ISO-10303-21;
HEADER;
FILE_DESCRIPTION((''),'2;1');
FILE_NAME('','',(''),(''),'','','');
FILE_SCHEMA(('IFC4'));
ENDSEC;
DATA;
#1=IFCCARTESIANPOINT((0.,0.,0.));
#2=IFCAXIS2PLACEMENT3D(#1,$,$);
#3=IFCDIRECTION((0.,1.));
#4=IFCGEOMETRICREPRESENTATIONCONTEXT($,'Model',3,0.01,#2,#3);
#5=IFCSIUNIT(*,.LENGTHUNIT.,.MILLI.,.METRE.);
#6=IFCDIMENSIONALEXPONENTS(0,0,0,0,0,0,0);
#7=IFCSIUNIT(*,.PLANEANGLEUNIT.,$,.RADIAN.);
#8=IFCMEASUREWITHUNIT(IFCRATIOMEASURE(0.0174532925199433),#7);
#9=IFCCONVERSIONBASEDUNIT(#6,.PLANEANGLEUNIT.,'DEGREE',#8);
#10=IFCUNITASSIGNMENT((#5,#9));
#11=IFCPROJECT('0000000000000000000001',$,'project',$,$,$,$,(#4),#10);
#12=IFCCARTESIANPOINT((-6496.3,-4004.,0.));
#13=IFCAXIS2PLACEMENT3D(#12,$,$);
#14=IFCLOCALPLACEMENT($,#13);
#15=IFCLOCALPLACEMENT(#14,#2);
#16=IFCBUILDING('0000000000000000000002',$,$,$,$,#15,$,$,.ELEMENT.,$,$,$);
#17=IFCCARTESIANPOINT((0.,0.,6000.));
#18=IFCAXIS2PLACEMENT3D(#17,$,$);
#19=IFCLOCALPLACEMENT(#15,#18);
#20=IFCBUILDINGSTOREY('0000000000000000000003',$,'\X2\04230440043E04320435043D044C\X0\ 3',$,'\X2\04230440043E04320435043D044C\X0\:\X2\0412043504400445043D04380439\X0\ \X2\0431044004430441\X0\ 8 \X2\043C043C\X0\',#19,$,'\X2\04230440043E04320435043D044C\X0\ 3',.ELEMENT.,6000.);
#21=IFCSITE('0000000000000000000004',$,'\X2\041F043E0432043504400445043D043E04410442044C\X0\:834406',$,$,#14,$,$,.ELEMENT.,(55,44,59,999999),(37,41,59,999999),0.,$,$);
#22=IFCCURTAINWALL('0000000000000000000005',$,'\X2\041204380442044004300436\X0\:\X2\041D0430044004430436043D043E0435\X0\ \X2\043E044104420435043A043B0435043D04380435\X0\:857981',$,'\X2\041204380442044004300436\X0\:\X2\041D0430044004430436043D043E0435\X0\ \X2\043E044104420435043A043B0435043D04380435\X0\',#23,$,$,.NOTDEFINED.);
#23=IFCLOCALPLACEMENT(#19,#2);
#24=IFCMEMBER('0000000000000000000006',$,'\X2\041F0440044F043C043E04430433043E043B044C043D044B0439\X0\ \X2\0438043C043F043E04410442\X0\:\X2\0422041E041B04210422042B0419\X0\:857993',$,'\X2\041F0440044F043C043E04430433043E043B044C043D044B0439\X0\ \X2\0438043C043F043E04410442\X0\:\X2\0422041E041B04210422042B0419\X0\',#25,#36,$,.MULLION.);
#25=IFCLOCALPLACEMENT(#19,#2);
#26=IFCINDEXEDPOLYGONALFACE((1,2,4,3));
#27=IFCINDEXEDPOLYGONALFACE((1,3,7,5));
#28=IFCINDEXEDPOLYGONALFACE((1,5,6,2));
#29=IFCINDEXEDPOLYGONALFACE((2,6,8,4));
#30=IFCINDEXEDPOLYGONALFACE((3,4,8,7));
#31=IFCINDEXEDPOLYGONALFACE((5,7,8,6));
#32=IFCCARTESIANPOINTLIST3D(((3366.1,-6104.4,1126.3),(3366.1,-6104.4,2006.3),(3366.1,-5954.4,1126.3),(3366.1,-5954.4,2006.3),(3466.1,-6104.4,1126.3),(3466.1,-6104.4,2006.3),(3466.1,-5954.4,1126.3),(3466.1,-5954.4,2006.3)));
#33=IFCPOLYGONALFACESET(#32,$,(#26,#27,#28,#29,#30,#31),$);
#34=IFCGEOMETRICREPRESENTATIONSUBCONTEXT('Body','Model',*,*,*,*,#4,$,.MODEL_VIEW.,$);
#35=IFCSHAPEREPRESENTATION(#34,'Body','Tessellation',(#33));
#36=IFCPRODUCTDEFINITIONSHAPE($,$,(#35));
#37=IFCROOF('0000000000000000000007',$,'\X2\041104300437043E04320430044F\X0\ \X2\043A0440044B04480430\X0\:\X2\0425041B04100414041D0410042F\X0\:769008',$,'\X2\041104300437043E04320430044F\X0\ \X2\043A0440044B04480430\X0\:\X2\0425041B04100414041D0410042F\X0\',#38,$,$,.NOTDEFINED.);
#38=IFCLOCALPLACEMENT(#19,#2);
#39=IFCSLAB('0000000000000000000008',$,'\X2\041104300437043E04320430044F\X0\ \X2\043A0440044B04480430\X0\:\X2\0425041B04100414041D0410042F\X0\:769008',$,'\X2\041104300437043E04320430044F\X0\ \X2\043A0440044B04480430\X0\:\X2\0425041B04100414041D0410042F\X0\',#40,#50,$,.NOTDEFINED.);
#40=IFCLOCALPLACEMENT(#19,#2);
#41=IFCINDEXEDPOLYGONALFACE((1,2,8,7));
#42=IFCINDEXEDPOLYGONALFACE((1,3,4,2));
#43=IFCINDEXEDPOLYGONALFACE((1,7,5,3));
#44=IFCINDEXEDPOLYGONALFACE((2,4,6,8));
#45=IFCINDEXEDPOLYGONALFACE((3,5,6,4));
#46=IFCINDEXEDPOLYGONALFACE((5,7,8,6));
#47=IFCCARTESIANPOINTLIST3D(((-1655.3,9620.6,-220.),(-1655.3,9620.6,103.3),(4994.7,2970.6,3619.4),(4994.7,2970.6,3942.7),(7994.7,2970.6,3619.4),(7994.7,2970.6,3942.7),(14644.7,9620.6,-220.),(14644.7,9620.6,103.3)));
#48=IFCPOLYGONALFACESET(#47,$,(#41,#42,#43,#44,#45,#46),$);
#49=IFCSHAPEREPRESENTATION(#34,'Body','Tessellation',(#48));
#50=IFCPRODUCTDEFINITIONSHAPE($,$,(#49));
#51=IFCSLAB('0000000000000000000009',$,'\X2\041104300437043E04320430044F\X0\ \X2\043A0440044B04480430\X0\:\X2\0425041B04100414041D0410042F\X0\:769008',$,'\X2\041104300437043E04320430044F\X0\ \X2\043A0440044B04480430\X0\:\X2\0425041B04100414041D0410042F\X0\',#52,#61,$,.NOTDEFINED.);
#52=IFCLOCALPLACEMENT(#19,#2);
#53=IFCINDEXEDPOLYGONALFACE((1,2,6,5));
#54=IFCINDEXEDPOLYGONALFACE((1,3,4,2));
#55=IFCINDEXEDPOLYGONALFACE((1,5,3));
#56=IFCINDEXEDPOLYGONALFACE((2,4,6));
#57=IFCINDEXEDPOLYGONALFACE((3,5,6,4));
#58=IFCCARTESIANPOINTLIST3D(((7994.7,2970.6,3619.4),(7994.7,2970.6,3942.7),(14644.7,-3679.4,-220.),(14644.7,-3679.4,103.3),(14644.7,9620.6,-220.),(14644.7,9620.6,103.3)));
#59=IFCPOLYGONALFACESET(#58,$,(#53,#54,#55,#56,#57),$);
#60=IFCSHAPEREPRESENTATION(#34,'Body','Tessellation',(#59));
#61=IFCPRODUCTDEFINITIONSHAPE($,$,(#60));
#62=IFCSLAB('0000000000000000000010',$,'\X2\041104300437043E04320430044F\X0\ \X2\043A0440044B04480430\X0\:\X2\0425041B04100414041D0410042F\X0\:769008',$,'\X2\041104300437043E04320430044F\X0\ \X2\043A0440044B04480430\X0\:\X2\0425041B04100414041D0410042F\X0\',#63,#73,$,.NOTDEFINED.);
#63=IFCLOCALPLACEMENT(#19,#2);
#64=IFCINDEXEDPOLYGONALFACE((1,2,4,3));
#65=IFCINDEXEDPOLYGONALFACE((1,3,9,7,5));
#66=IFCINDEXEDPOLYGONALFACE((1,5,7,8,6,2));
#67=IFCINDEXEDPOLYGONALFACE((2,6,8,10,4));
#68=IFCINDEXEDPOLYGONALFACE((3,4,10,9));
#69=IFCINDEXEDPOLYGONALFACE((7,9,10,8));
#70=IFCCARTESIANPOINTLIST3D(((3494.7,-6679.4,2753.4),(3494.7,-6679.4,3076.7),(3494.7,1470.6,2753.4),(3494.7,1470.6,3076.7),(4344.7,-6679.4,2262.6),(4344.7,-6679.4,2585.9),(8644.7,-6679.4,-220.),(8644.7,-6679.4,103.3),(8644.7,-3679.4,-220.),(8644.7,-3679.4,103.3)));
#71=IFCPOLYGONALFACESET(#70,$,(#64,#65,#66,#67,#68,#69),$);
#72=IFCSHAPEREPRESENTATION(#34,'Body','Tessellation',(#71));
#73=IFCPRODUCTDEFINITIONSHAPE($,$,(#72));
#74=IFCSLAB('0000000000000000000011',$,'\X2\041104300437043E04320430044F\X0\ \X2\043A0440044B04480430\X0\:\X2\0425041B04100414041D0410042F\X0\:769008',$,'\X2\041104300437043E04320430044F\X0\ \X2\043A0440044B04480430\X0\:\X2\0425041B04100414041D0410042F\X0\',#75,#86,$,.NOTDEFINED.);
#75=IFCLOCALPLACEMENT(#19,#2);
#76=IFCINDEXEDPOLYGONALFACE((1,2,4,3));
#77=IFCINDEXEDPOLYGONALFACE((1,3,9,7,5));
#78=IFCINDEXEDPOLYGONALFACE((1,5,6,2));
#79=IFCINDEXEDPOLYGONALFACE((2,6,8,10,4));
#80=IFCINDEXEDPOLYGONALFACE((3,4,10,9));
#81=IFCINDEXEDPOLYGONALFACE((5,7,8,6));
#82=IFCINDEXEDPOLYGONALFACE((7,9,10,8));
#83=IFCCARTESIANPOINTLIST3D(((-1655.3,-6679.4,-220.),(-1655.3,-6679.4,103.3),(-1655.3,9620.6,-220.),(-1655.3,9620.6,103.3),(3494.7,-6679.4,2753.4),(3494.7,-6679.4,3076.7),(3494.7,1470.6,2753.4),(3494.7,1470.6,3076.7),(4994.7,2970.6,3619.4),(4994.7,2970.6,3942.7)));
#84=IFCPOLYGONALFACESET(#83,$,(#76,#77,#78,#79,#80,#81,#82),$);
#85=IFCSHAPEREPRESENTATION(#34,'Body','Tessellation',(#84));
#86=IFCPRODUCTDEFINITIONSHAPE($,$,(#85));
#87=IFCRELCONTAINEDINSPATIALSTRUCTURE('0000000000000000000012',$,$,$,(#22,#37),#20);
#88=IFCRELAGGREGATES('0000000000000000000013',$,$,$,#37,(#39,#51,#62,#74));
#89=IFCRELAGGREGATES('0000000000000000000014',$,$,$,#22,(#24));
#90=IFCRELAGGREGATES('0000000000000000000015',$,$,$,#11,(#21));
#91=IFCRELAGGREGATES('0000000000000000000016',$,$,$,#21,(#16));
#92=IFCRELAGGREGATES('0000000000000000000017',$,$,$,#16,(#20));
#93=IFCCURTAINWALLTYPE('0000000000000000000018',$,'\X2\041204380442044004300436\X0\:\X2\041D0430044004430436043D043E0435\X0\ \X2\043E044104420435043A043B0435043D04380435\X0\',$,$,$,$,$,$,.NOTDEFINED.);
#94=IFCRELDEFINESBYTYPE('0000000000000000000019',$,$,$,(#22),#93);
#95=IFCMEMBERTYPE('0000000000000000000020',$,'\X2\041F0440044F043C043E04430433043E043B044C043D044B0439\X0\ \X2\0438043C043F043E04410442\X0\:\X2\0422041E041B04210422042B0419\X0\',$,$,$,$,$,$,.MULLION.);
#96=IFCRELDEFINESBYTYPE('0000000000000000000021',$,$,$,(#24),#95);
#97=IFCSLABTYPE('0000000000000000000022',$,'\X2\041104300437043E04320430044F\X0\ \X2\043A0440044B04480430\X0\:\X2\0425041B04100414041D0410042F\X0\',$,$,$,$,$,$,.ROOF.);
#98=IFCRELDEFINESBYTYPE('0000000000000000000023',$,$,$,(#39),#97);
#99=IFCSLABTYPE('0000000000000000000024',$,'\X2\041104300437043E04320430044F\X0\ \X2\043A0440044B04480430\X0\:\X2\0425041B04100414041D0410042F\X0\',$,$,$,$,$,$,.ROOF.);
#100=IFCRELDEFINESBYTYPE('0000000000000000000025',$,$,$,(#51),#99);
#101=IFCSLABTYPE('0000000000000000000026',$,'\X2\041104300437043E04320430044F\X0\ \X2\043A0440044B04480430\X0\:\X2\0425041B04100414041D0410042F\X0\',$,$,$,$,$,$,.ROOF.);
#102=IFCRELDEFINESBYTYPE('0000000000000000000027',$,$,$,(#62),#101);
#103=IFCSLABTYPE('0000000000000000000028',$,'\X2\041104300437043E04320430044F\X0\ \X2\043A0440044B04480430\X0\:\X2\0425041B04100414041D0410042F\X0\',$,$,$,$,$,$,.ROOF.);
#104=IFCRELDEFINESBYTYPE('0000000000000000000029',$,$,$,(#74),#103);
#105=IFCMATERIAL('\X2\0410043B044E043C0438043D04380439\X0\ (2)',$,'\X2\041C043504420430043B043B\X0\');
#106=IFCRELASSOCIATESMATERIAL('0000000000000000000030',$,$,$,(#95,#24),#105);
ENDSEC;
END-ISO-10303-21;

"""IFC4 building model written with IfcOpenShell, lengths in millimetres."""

from ifc_helpers import new_model, entity, si_unit, converted_unit, direction, frame, origin, place, context, subcontext, project, spatial, indexed_curve, outline, extrude, source, transform, mapped, material, type_object, type_shapes, element, aggregate, save


model = new_model("IFC4")

# Units and contexts
model_context = context("Model", 3, precision=0.01, world=origin(), true_north=direction((0.0, 1.0)))
body_context = subcontext(model_context, "Body", "Model", "MODEL_VIEW")
ifc_project = project(units=[si_unit("LENGTHUNIT", "METRE", prefix="MILLI"), converted_unit("PLANEANGLEUNIT", "DEGREE", entity("IfcRatioMeasure", 0.0174532925199433), si_unit("PLANEANGLEUNIT", "RADIAN"), dimensions=[0, 0, 0, 0, 0, 0, 0])], contexts=[model_context])

# Site, building, storey
site_placement = place(None, frame((-6496.3, -4004.0, 0.0)))
site = spatial("IfcSite", under=ifc_project, at=site_placement, Name="Поверхность:834406", CompositionType="ELEMENT", RefLatitude=(55, 44, 59, 999999), RefLongitude=(37, 41, 59, 999999), RefElevation=0.0)
building_placement = place(site_placement, origin())
building = spatial("IfcBuilding", under=site, at=building_placement, CompositionType="ELEMENT")
storey_placement = place(building_placement, frame((0.0, 0.0, 6000.0)))
storey = spatial("IfcBuildingStorey", under=building, at=storey_placement, Name="Уровень 3", ObjectType="Уровень:Верхний брус 8 мм", LongName="Уровень 3", CompositionType="ELEMENT", Elevation=6000.0)

# Curtain wall, member
curtain_wall_type = type_object("IfcCurtainWallType", Name="Витраж:Наружное остекление", PredefinedType="NOTDEFINED")
curtain_wall_placement = place(storey_placement, frame((0.0, 0.0, -6000.0)))
curtain_wall = element("IfcCurtainWall", 1, at=curtain_wall_placement, inside=storey, type_object=curtain_wall_type, Name="Витраж:Наружное остекление:857981", ObjectType="Витраж:Наружное остекление", PredefinedType="NOTDEFINED")
ifc_material_1 = material(Name="Алюминий (2)", Category="Металл")
member_type = type_object("IfcMemberType", Name="Прямоугольный импост:ТОЛСТЫЙ", PredefinedType="MULLION", material=ifc_material_1)
shared_shape_1 = source(origin(), body_context, "Body", "SweptSolid", [
    extrude(outline(indexed_curve([(-75.0, -50.0), (75.0, -50.0), (75.0, 50.0), (-75.0, 50.0), (-75.0, -50.0)], self_intersect=False)), frame((0.0, 0.0, -880.0), z_axis=(0.0, 0.0, 1.0), x_axis=(0.0, -1.0, 0.0)), (0.0, 0.0, 1.0), 880.0),
])
type_shapes(member_type, [shared_shape_1])
member_placement = place(storey_placement, frame((3416.1, -6029.4, 1126.3), z_axis=(0.0, 0.0, -1.0), x_axis=(-1.0, 0.0, 0.0)))
member = element("IfcMember", 2, at=member_placement, type_object=member_type, material=ifc_material_1, Name="Прямоугольный импост:ТОЛСТЫЙ:857993", ObjectType="Прямоугольный импост:ТОЛСТЫЙ", PredefinedType="MULLION", context=body_context, shape_type="MappedRepresentation", body=[
    mapped(shared_shape_1, transform((0.0, 0.0, 0.0), scale=1.0)),
])

# Roof, slabs
roof_placement = place(storey_placement, frame((-1655.3, -6679.4, -220.0)))
roof = element("IfcRoof", 3, at=roof_placement, inside=storey, Name="Базовая крыша:ХЛАДНАЯ:769008", ObjectType="Базовая крыша:ХЛАДНАЯ", PredefinedType="NOTDEFINED")
slab_type_1 = type_object("IfcSlabType", Name="Базовая крыша:ХЛАДНАЯ", PredefinedType="ROOF")
slab_1_placement = place(roof_placement, origin())
slab_1 = element("IfcSlab", 4, at=slab_1_placement, type_object=slab_type_1, Name="Базовая крыша:ХЛАДНАЯ:769008", ObjectType="Базовая крыша:ХЛАДНАЯ", PredefinedType="NOTDEFINED", context=body_context, shape_type="SweptSolid", body=[
    extrude(outline(indexed_curve([(8150.0, 3839.4), (-8150.0, 3839.4), (-1500.0, -3839.4), (1500.0, -3839.4), (8150.0, 3839.4)], self_intersect=False)), frame((8150.0, 12975.0, 1919.7), z_axis=(0.0, 0.5, 0.866025), x_axis=(1.0, 0.0, 0.0)), (0.0, -0.5, 0.866025), 323.3),
])
slab_type_2 = type_object("IfcSlabType", Name="Базовая крыша:ХЛАДНАЯ", PredefinedType="ROOF")
slab_2_placement = place(roof_placement, origin())
slab_2 = element("IfcSlab", 5, at=slab_2_placement, type_object=slab_type_2, Name="Базовая крыша:ХЛАДНАЯ:769008", ObjectType="Базовая крыша:ХЛАДНАЯ", PredefinedType="NOTDEFINED", context=body_context, shape_type="SweptSolid", body=[
    extrude(outline(indexed_curve([(3839.4, -6650.0), (3839.4, 6650.0), (-3839.4, 0.0), (3839.4, -6650.0)], self_intersect=False)), frame((12975.0, 9650.0, 1919.7), z_axis=(0.5, 0.0, 0.866025), x_axis=(0.866025, 0.0, -0.5)), (-0.5, 0.0, 0.866025), 323.3),
])
slab_type_3 = type_object("IfcSlabType", Name="Базовая крыша:ХЛАДНАЯ", PredefinedType="ROOF")
slab_3_placement = place(roof_placement, origin())
slab_3 = element("IfcSlab", 6, at=slab_3_placement, type_object=slab_type_3, Name="Базовая крыша:ХЛАДНАЯ:769008", ObjectType="Базовая крыша:ХЛАДНАЯ", PredefinedType="NOTDEFINED", context=body_context, shape_type="SweptSolid", body=[
    extrude(outline(indexed_curve([(-1991.9, -4075.0), (2973.4, -4075.0), (2973.4, -1075.0), (-2973.4, 4075.0), (-2973.4, -4075.0), (-1991.9, -4075.0)], self_intersect=False)), frame((7725.0, 4075.0, 1486.7), z_axis=(0.5, 0.0, 0.866025), x_axis=(0.866025, 0.0, -0.5)), (-0.5, 0.0, 0.866025), 323.3),
])
slab_type_4 = type_object("IfcSlabType", Name="Базовая крыша:ХЛАДНАЯ", PredefinedType="ROOF")
slab_4_placement = place(roof_placement, origin())
slab_4 = element("IfcSlab", 7, at=slab_4_placement, type_object=slab_type_4, Name="Базовая крыша:ХЛАДНАЯ:769008", ObjectType="Базовая крыша:ХЛАДНАЯ", PredefinedType="NOTDEFINED", context=body_context, shape_type="SweptSolid", body=[
    extrude(outline(indexed_curve([(-3839.4, 8150.0), (-3839.4, -8150.0), (2107.3, -8150.0), (2107.3, 0.0), (3839.4, 1500.0), (-3839.4, 8150.0)], self_intersect=False)), frame((3325.0, 8150.0, 1919.7), z_axis=(-0.5, 0.0, 0.866025), x_axis=(0.866025, 0.0, 0.5)), (0.5, 0.0, 0.866025), 323.3),
])
aggregate(roof, [slab_1, slab_2, slab_3, slab_4])

aggregate(curtain_wall, [member])

save(model, "model.ifc")
